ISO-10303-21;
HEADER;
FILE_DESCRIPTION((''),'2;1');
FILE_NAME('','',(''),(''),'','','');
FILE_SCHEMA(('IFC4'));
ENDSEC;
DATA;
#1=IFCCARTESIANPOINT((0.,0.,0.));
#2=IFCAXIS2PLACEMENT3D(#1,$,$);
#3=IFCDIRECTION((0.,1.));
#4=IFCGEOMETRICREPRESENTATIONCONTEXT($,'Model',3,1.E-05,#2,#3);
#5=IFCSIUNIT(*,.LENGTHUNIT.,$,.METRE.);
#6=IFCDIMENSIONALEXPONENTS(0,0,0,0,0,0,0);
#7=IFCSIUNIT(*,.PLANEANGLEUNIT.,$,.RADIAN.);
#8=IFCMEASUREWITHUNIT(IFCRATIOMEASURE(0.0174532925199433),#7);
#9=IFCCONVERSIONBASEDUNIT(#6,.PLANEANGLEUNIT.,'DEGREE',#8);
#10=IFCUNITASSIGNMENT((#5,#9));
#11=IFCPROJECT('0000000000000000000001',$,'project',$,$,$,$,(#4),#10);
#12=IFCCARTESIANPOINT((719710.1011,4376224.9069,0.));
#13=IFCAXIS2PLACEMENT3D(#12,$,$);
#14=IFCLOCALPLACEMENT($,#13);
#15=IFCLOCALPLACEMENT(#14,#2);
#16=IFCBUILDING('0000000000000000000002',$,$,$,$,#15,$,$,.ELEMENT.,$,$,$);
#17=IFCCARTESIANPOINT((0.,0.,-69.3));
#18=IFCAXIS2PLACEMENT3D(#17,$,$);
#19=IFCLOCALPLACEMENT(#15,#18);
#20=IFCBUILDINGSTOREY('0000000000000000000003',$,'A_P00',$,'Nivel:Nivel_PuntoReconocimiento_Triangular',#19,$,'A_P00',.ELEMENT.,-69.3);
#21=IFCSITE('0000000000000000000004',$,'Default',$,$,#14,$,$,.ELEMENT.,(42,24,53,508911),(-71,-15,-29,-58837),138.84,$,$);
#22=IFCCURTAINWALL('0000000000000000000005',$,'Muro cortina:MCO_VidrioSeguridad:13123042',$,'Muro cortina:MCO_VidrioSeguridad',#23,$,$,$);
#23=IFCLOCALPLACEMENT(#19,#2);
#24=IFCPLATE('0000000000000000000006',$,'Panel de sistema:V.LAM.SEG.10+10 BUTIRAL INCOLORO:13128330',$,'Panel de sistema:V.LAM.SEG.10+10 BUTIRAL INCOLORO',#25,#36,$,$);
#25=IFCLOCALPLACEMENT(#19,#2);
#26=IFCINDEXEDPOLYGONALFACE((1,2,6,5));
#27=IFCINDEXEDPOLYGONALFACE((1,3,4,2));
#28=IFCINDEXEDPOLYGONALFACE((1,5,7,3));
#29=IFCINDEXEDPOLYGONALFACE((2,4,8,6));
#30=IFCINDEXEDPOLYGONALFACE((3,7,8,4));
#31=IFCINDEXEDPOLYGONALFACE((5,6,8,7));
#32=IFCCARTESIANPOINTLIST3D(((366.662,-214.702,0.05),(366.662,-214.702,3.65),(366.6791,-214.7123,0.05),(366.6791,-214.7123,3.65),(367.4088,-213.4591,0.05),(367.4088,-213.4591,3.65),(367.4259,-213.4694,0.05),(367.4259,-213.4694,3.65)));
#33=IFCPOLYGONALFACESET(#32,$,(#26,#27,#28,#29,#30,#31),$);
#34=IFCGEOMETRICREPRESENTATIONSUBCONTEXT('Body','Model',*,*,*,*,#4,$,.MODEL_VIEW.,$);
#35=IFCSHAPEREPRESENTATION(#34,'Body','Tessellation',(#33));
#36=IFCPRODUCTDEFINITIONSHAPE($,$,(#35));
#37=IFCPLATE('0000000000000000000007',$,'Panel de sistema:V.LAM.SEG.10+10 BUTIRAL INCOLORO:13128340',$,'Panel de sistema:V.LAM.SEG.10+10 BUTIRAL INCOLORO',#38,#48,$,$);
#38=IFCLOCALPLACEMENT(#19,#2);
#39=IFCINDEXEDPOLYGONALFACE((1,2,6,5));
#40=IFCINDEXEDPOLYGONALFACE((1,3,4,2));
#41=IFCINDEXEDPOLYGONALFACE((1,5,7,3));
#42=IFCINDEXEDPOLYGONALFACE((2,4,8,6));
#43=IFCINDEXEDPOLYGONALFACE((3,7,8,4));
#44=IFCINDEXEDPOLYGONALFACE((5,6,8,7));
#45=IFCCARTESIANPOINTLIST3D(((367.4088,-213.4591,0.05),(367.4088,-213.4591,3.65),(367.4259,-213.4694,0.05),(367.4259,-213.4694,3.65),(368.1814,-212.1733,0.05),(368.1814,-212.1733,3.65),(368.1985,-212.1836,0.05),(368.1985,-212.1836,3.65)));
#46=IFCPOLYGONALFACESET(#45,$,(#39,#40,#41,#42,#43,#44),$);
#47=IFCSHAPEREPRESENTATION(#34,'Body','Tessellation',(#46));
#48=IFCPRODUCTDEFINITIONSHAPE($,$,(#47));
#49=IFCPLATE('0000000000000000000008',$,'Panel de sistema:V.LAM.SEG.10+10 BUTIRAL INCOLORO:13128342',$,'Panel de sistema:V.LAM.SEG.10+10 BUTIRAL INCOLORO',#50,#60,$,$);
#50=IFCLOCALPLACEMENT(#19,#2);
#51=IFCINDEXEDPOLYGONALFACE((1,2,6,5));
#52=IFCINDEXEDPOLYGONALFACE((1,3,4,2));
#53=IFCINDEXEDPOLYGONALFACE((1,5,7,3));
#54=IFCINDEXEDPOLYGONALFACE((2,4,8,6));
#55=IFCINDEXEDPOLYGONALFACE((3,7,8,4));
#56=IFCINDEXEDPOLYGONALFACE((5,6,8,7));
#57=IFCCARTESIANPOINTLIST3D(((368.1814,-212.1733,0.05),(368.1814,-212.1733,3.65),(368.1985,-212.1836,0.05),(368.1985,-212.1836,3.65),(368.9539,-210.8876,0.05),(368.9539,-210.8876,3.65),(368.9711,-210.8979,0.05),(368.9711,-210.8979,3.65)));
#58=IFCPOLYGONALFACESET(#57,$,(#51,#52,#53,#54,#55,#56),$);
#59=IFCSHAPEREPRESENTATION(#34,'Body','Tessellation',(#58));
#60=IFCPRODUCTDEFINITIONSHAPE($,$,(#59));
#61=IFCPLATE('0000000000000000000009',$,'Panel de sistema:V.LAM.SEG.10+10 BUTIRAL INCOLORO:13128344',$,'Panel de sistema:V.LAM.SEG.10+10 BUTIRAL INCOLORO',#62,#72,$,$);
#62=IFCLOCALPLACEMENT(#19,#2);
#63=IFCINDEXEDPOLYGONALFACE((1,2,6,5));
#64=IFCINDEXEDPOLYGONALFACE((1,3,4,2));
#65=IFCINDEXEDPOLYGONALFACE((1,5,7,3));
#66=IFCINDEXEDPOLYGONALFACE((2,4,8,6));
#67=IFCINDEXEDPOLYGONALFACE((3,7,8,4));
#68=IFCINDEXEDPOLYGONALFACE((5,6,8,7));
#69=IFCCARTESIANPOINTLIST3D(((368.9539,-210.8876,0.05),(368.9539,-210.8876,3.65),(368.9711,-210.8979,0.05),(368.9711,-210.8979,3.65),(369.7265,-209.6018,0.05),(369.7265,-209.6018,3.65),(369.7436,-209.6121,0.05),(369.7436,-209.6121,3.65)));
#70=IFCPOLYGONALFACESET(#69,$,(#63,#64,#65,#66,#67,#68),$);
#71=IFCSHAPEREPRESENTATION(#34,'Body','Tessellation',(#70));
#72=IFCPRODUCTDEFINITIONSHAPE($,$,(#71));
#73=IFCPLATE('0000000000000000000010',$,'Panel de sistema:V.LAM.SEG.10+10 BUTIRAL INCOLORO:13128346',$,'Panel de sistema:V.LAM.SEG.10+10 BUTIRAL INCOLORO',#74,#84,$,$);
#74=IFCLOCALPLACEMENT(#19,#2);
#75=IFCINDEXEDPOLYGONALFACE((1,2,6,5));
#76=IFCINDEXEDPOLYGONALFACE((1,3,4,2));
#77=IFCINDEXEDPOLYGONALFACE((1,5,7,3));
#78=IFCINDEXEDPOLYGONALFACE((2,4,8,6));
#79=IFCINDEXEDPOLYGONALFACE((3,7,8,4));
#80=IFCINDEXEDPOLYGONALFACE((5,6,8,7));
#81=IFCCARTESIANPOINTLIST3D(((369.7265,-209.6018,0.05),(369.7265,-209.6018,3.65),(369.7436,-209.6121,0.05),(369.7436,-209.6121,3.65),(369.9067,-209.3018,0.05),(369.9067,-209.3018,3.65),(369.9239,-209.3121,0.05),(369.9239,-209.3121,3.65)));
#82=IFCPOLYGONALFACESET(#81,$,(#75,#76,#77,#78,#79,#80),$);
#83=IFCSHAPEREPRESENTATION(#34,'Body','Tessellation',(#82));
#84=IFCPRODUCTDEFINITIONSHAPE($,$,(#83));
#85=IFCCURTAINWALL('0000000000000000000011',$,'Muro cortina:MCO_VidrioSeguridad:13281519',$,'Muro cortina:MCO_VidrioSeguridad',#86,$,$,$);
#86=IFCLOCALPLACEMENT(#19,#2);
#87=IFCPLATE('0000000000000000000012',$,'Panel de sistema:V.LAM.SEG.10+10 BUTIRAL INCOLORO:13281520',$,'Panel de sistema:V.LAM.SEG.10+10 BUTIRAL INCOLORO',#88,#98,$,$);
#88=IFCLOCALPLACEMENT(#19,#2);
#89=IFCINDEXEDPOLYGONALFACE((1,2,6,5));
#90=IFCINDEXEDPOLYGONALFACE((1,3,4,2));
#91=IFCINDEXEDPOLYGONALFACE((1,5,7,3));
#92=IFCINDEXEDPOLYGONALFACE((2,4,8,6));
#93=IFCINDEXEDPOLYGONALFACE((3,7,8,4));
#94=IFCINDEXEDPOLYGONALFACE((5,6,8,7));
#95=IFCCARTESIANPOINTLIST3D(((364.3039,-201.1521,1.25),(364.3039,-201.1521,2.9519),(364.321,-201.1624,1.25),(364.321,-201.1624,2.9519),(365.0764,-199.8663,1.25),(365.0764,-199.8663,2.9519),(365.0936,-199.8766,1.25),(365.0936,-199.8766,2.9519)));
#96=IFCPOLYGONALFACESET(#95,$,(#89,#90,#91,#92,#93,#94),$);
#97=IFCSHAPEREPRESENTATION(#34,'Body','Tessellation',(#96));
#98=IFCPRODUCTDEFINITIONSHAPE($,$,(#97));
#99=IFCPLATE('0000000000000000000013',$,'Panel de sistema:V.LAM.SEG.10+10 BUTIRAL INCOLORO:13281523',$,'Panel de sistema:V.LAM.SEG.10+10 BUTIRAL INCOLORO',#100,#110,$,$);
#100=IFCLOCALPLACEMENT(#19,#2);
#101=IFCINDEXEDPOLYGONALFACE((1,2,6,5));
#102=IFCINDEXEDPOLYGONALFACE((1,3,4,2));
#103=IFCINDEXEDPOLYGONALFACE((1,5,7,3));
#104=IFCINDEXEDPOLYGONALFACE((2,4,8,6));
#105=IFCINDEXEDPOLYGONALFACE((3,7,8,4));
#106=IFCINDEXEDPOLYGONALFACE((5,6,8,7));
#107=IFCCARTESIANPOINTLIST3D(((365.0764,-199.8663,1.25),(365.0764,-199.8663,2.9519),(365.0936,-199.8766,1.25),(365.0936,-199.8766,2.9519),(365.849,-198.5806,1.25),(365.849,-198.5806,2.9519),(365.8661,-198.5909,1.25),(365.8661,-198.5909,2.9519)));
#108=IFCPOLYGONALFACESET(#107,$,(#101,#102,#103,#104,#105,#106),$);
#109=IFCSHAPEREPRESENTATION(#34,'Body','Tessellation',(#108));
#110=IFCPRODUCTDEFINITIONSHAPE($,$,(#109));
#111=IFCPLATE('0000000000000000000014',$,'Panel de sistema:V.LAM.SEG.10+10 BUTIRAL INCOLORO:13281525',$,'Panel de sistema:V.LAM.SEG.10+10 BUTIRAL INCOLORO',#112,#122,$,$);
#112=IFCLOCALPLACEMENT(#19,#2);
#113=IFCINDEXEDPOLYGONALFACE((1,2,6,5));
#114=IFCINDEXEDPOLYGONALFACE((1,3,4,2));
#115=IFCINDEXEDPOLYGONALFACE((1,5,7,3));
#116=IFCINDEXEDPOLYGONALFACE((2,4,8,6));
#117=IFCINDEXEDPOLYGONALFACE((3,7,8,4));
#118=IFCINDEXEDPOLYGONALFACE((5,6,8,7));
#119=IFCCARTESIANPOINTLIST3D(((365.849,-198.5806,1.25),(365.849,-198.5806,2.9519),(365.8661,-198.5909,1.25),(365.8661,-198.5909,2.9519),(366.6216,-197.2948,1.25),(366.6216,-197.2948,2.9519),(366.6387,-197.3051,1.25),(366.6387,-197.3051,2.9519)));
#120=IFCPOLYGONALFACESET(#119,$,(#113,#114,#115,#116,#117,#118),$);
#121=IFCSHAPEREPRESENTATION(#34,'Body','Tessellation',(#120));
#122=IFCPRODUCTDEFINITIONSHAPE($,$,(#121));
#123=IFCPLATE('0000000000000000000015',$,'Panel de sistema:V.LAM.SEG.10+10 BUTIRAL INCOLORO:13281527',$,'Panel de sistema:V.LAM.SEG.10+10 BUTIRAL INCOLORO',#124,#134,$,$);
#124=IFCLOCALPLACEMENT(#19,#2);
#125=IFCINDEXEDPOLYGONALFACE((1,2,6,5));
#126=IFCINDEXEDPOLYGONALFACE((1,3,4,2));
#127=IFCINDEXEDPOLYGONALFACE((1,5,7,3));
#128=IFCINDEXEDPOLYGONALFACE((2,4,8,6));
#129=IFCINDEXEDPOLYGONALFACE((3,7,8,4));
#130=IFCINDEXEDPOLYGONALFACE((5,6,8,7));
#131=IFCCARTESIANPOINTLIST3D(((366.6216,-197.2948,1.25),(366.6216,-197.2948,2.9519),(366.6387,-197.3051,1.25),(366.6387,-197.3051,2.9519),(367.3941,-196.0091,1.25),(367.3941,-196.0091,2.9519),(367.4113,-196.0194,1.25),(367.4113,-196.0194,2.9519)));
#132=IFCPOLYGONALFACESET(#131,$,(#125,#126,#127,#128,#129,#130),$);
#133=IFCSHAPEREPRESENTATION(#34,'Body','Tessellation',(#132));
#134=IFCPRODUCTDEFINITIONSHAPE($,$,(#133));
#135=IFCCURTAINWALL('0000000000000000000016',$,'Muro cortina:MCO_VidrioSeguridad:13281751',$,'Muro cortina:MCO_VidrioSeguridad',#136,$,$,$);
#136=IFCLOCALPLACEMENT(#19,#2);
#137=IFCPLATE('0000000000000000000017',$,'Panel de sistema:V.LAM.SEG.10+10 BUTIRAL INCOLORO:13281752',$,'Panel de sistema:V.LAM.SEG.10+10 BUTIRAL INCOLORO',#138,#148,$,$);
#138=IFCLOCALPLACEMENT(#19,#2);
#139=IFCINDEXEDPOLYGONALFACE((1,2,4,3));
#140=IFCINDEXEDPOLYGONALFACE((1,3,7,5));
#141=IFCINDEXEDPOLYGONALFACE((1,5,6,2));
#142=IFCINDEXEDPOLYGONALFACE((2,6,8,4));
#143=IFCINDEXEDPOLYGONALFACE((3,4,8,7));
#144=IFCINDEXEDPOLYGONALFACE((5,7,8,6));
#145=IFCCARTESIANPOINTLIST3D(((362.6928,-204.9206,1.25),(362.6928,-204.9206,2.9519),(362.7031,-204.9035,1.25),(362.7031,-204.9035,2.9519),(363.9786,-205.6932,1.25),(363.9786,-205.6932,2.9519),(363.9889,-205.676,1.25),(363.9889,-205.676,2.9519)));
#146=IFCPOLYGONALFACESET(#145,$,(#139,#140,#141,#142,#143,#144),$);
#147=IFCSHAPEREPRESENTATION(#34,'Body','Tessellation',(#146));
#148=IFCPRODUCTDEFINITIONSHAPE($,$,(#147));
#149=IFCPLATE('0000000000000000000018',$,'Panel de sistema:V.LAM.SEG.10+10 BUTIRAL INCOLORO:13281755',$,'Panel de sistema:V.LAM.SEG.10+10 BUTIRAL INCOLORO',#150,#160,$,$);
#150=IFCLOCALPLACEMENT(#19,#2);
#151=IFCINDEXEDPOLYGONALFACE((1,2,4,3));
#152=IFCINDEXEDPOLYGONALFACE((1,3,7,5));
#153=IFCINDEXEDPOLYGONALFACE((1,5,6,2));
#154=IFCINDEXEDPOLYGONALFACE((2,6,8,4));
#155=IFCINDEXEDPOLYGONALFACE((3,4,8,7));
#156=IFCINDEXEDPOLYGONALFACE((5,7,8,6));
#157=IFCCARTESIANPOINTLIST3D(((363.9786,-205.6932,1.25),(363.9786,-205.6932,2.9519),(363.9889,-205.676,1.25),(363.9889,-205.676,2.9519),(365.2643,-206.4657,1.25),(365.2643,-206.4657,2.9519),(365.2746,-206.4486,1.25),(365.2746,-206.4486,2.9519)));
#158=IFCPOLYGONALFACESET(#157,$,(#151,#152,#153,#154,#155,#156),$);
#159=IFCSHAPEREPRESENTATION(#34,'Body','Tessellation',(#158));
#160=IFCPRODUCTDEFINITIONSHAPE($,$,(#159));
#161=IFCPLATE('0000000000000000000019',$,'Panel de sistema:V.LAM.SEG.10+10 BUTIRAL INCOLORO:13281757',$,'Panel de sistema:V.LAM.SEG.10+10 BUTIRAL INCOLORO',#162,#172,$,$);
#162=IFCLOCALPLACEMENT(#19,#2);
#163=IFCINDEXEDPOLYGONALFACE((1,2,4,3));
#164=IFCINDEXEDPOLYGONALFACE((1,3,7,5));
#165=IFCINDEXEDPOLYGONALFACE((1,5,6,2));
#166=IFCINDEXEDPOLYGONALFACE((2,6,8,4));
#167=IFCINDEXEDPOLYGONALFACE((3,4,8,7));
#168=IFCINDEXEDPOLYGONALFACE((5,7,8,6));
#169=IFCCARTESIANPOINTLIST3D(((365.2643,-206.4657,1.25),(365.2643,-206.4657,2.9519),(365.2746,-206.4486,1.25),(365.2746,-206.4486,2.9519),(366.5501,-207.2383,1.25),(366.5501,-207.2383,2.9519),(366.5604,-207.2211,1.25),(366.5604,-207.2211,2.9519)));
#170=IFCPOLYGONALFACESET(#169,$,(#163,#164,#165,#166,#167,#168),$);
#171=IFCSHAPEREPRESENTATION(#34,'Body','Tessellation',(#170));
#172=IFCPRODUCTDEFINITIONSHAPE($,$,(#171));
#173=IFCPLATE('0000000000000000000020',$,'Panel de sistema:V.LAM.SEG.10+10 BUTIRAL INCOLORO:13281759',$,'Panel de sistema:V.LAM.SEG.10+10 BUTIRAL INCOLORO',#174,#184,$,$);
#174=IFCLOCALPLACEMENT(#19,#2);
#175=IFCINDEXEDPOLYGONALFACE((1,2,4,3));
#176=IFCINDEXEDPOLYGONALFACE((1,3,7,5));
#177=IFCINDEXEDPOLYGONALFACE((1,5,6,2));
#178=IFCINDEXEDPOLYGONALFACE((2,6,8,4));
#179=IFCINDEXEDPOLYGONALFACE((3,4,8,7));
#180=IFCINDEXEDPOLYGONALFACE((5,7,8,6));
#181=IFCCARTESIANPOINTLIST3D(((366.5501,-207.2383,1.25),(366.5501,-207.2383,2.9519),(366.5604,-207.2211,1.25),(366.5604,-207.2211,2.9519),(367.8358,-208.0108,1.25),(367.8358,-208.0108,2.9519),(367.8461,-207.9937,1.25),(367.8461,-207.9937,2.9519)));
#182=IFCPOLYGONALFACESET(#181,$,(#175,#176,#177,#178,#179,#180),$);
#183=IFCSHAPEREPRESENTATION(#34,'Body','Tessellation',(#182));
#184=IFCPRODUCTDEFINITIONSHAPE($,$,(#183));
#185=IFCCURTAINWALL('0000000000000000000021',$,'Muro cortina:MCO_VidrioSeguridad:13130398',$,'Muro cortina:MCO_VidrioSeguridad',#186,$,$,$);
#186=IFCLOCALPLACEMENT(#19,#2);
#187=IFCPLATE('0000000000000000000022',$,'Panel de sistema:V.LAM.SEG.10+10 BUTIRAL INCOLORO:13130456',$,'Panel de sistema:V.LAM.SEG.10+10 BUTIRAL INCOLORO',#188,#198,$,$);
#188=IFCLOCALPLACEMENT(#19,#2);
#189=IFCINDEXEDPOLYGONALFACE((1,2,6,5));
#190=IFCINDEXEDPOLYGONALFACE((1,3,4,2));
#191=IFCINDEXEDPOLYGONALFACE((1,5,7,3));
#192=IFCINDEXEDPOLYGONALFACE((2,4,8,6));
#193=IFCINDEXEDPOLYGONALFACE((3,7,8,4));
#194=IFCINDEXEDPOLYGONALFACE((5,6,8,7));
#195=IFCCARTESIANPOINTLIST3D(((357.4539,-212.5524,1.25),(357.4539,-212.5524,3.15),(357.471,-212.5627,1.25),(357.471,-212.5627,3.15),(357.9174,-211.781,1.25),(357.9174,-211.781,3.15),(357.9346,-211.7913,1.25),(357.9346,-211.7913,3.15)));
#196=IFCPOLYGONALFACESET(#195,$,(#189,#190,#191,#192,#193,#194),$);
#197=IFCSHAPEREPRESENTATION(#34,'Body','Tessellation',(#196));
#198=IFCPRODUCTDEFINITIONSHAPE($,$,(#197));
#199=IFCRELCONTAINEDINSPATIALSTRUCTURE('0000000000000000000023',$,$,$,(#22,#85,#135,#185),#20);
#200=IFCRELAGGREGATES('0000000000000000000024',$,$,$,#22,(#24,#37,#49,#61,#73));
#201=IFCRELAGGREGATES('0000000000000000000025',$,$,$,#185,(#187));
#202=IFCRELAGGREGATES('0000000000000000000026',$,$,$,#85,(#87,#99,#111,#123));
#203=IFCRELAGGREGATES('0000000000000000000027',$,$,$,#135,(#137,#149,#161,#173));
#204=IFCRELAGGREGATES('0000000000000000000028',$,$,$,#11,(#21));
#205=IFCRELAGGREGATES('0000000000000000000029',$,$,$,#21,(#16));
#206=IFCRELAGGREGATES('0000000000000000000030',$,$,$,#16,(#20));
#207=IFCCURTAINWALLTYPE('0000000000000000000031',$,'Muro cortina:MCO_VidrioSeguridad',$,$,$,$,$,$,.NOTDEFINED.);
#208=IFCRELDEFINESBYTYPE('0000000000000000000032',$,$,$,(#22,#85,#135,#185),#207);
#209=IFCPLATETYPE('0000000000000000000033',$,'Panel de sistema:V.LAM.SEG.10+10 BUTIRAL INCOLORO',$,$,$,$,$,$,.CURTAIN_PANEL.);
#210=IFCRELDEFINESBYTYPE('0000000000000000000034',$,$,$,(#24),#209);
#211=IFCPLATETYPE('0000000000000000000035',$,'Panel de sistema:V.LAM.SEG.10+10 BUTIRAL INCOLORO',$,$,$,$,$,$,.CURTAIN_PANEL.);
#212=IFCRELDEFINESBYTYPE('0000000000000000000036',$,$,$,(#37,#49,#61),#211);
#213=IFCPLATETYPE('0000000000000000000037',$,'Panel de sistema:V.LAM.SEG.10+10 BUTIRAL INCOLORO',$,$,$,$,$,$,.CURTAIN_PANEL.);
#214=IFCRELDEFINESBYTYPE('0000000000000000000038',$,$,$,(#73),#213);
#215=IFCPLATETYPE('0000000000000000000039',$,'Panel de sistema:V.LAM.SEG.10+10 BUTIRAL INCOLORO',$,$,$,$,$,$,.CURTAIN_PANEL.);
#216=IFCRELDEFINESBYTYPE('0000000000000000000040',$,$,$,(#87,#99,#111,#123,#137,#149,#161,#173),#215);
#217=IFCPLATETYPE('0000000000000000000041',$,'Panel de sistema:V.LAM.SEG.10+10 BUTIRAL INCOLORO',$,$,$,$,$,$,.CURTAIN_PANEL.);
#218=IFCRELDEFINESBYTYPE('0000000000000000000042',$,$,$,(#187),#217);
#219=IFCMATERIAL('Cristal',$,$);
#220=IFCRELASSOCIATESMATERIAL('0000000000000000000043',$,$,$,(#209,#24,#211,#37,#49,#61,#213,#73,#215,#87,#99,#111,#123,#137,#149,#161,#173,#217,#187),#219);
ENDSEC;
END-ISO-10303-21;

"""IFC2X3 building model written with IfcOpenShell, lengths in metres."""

from ifc_helpers import new_model, entity, si_unit, converted_unit, direction, frame, frame_2d, origin, origin_2d_with_axis, place, context, subcontext, project, spatial, rectangle, extrude, source, transform, mapped, material, type_object, type_shapes, element, aggregate, save


model = new_model("IFC2X3")

# Units and contexts
model_context = context("Model", 3, precision=1e-05, world=origin(), true_north=direction((0.0, 1.0)))
body_context = subcontext(model_context, "Body", "Model", "MODEL_VIEW")
ifc_project = project(units=[si_unit("LENGTHUNIT", "METRE"), converted_unit("PLANEANGLEUNIT", "DEGREE", entity("IfcRatioMeasure", 0.0174532925199433), si_unit("PLANEANGLEUNIT", "RADIAN"), dimensions=[0, 0, 0, 0, 0, 0, 0])], contexts=[model_context])

# Site, building, storey
site_placement = place(None, frame((719710.1011, 4376224.9069, 0.0)))
site = spatial("IfcSite", under=ifc_project, at=site_placement, Name="Default", CompositionType="ELEMENT", RefLatitude=(42, 24, 53, 508911), RefLongitude=(-71, -15, -29, -58837), RefElevation=138.84)
building_placement = place(site_placement, origin())
building = spatial("IfcBuilding", under=site, at=building_placement, CompositionType="ELEMENT")
storey_placement = place(building_placement, frame((0.0, 0.0, -69.3)))
storey = spatial("IfcBuildingStorey", under=building, at=storey_placement, Name="A_P00", ObjectType="Nivel:Nivel_PuntoReconocimiento_Triangular", LongName="A_P00", CompositionType="ELEMENT", Elevation=-69.3)

# Curtain walls, plates
curtain_wall_type = type_object("IfcCurtainWallType", Name="Muro cortina:MCO_VidrioSeguridad", PredefinedType="NOTDEFINED")
curtain_wall_1_placement = place(storey_placement, frame((0.0, 0.0, 69.3)))
curtain_wall_1 = element("IfcCurtainWall", 1, at=curtain_wall_1_placement, inside=storey, type_object=curtain_wall_type, Name="Muro cortina:MCO_VidrioSeguridad:13123042", ObjectType="Muro cortina:MCO_VidrioSeguridad")
ifc_material_1 = material(Name="Cristal")
plate_type_1 = type_object("IfcPlateType", Name="Panel de sistema:V.LAM.SEG.10+10 BUTIRAL INCOLORO", PredefinedType="CURTAIN_PANEL", material=ifc_material_1)
shared_shape_1 = source(origin(), body_context, "Body", "SweptSolid", [
    extrude(rectangle(XDim=0.02, YDim=1.45, at=frame_2d((0.0, 0.0), x_axis=(1.0, 0.0))), frame((0.0, 0.0, 0.0), z_axis=(0.0, 0.0, 1.0), x_axis=(0.0, 1.0, 0.0)), (0.0, 0.0, 1.0), 3.6),
])
type_shapes(plate_type_1, [shared_shape_1])
plate_1_placement = place(curtain_wall_1_placement, frame((367.044, -214.0857, -69.25), z_axis=(0.0, 0.0, 1.0), x_axis=(0.515038, 0.857167, 0.0)))
plate_1 = element("IfcPlate", 2, at=plate_1_placement, type_object=plate_type_1, material=ifc_material_1, Name="Panel de sistema:V.LAM.SEG.10+10 BUTIRAL INCOLORO:13128330", ObjectType="Panel de sistema:V.LAM.SEG.10+10 BUTIRAL INCOLORO", context=body_context, shape_type="MappedRepresentation", body=[
    mapped(shared_shape_1, transform((0.0, 0.0, 0.0), scale=1.0)),
])
plate_type_2 = type_object("IfcPlateType", Name="Panel de sistema:V.LAM.SEG.10+10 BUTIRAL INCOLORO", PredefinedType="CURTAIN_PANEL", material=ifc_material_1)
shared_shape_2 = source(origin(), body_context, "Body", "SweptSolid", [
    extrude(rectangle(XDim=0.02, YDim=1.5, at=frame_2d((0.0, 0.0), x_axis=(1.0, 0.0))), frame((0.0, 0.0, 0.0), z_axis=(0.0, 0.0, 1.0), x_axis=(0.0, 1.0, 0.0)), (0.0, 0.0, 1.0), 3.6),
])
type_shapes(plate_type_2, [shared_shape_2])
plate_2_placement = place(curtain_wall_1_placement, frame((367.8036, -212.8213, -69.25), z_axis=(0.0, 0.0, 1.0), x_axis=(0.515038, 0.857167, 0.0)))
plate_2 = element("IfcPlate", 3, at=plate_2_placement, type_object=plate_type_2, material=ifc_material_1, Name="Panel de sistema:V.LAM.SEG.10+10 BUTIRAL INCOLORO:13128340", ObjectType="Panel de sistema:V.LAM.SEG.10+10 BUTIRAL INCOLORO", context=body_context, shape_type="MappedRepresentation", body=[
    mapped(shared_shape_2, transform((0.0, 0.0, 0.0), scale=1.0)),
])
plate_3_placement = place(curtain_wall_1_placement, frame((368.5762, -211.5356, -69.25), z_axis=(0.0, 0.0, 1.0), x_axis=(0.515038, 0.857167, 0.0)))
plate_3 = element("IfcPlate", 4, at=plate_3_placement, type_object=plate_type_2, material=ifc_material_1, Name="Panel de sistema:V.LAM.SEG.10+10 BUTIRAL INCOLORO:13128342", ObjectType="Panel de sistema:V.LAM.SEG.10+10 BUTIRAL INCOLORO", context=body_context, shape_type="MappedRepresentation", body=[
    mapped(shared_shape_2, transform((0.0, 0.0, 0.0), scale=1.0)),
])
plate_4_placement = place(curtain_wall_1_placement, frame((369.3488, -210.2498, -69.25), z_axis=(0.0, 0.0, 1.0), x_axis=(0.515038, 0.857167, 0.0)))
plate_4 = element("IfcPlate", 5, at=plate_4_placement, type_object=plate_type_2, material=ifc_material_1, Name="Panel de sistema:V.LAM.SEG.10+10 BUTIRAL INCOLORO:13128344", ObjectType="Panel de sistema:V.LAM.SEG.10+10 BUTIRAL INCOLORO", context=body_context, shape_type="MappedRepresentation", body=[
    mapped(shared_shape_2, transform((0.0, 0.0, 0.0), scale=1.0)),
])
plate_type_3 = type_object("IfcPlateType", Name="Panel de sistema:V.LAM.SEG.10+10 BUTIRAL INCOLORO", PredefinedType="CURTAIN_PANEL", material=ifc_material_1)
shared_shape_3 = source(origin(), body_context, "Body", "SweptSolid", [
    extrude(rectangle(XDim=0.02, YDim=0.35, at=origin_2d_with_axis()), frame((0.0, 0.0, 0.0), z_axis=(0.0, 0.0, 1.0), x_axis=(0.0, 1.0, 0.0)), (0.0, 0.0, 1.0), 3.6),
])
type_shapes(plate_type_3, [shared_shape_3])
plate_5_placement = place(curtain_wall_1_placement, frame((369.8252, -209.457, -69.25), z_axis=(0.0, 0.0, 1.0), x_axis=(0.515038, 0.857167, 0.0)))
plate_5 = element("IfcPlate", 6, at=plate_5_placement, type_object=plate_type_3, material=ifc_material_1, Name="Panel de sistema:V.LAM.SEG.10+10 BUTIRAL INCOLORO:13128346", ObjectType="Panel de sistema:V.LAM.SEG.10+10 BUTIRAL INCOLORO", context=body_context, shape_type="MappedRepresentation", body=[
    mapped(shared_shape_3, transform((0.0, 0.0, 0.0), scale=1.0)),
])
aggregate(curtain_wall_1, [plate_1, plate_2, plate_3, plate_4, plate_5])
curtain_wall_2_placement = place(storey_placement, frame((0.0, 0.0, 69.3)))
curtain_wall_2 = element("IfcCurtainWall", 7, at=curtain_wall_2_placement, inside=storey, type_object=curtain_wall_type, Name="Muro cortina:MCO_VidrioSeguridad:13281519", ObjectType="Muro cortina:MCO_VidrioSeguridad")
plate_type_4 = type_object("IfcPlateType", Name="Panel de sistema:V.LAM.SEG.10+10 BUTIRAL INCOLORO", PredefinedType="CURTAIN_PANEL", material=ifc_material_1)
shared_shape_4 = source(origin(), body_context, "Body", "SweptSolid", [
    extrude(rectangle(XDim=0.02, YDim=1.5, at=frame_2d((0.0, 0.0), x_axis=(1.0, 0.0))), frame((0.0, 0.0, 0.0), z_axis=(0.0, 0.0, 1.0), x_axis=(0.0, 1.0, 0.0)), (0.0, 0.0, 1.0), 1.7019),
])
type_shapes(plate_type_4, [shared_shape_4])
plate_6_placement = place(curtain_wall_2_placement, frame((364.6987, -200.5144, -68.05), z_axis=(0.0, 0.0, 1.0), x_axis=(0.515038, 0.857167, 0.0)))
plate_6 = element("IfcPlate", 8, at=plate_6_placement, type_object=plate_type_4, material=ifc_material_1, Name="Panel de sistema:V.LAM.SEG.10+10 BUTIRAL INCOLORO:13281520", ObjectType="Panel de sistema:V.LAM.SEG.10+10 BUTIRAL INCOLORO", context=body_context, shape_type="MappedRepresentation", body=[
    mapped(shared_shape_4, transform((0.0, 0.0, 0.0), scale=1.0)),
])
plate_7_placement = place(curtain_wall_2_placement, frame((365.4713, -199.2286, -68.05), z_axis=(0.0, 0.0, 1.0), x_axis=(0.515038, 0.857167, 0.0)))
plate_7 = element("IfcPlate", 9, at=plate_7_placement, type_object=plate_type_4, material=ifc_material_1, Name="Panel de sistema:V.LAM.SEG.10+10 BUTIRAL INCOLORO:13281523", ObjectType="Panel de sistema:V.LAM.SEG.10+10 BUTIRAL INCOLORO", context=body_context, shape_type="MappedRepresentation", body=[
    mapped(shared_shape_4, transform((0.0, 0.0, 0.0), scale=1.0)),
])
plate_8_placement = place(curtain_wall_2_placement, frame((366.2438, -197.9429, -68.05), z_axis=(0.0, 0.0, 1.0), x_axis=(0.515038, 0.857167, 0.0)))
plate_8 = element("IfcPlate", 10, at=plate_8_placement, type_object=plate_type_4, material=ifc_material_1, Name="Panel de sistema:V.LAM.SEG.10+10 BUTIRAL INCOLORO:13281525", ObjectType="Panel de sistema:V.LAM.SEG.10+10 BUTIRAL INCOLORO", context=body_context, shape_type="MappedRepresentation", body=[
    mapped(shared_shape_4, transform((0.0, 0.0, 0.0), scale=1.0)),
])
plate_9_placement = place(curtain_wall_2_placement, frame((367.0164, -196.6571, -68.05), z_axis=(0.0, 0.0, 1.0), x_axis=(0.515038, 0.857167, 0.0)))
plate_9 = element("IfcPlate", 11, at=plate_9_placement, type_object=plate_type_4, material=ifc_material_1, Name="Panel de sistema:V.LAM.SEG.10+10 BUTIRAL INCOLORO:13281527", ObjectType="Panel de sistema:V.LAM.SEG.10+10 BUTIRAL INCOLORO", context=body_context, shape_type="MappedRepresentation", body=[
    mapped(shared_shape_4, transform((0.0, 0.0, 0.0), scale=1.0)),
])
curtain_wall_3_placement = place(storey_placement, frame((0.0, 0.0, 69.3)))
curtain_wall_3 = element("IfcCurtainWall", 12, at=curtain_wall_3_placement, inside=storey, type_object=curtain_wall_type, Name="Muro cortina:MCO_VidrioSeguridad:13281751", ObjectType="Muro cortina:MCO_VidrioSeguridad")
plate_10_placement = place(curtain_wall_3_placement, frame((363.3409, -205.2983, -68.05), z_axis=(0.0, 0.0, 1.0), x_axis=(0.857167, -0.515038, 0.0)))
plate_10 = element("IfcPlate", 13, at=plate_10_placement, type_object=plate_type_4, material=ifc_material_1, Name="Panel de sistema:V.LAM.SEG.10+10 BUTIRAL INCOLORO:13281752", ObjectType="Panel de sistema:V.LAM.SEG.10+10 BUTIRAL INCOLORO", context=body_context, shape_type="MappedRepresentation", body=[
    mapped(shared_shape_4, transform((0.0, 0.0, 0.0), scale=1.0)),
])
plate_11_placement = place(curtain_wall_3_placement, frame((364.6266, -206.0709, -68.05), z_axis=(0.0, 0.0, 1.0), x_axis=(0.857167, -0.515038, 0.0)))
plate_11 = element("IfcPlate", 14, at=plate_11_placement, type_object=plate_type_4, material=ifc_material_1, Name="Panel de sistema:V.LAM.SEG.10+10 BUTIRAL INCOLORO:13281755", ObjectType="Panel de sistema:V.LAM.SEG.10+10 BUTIRAL INCOLORO", context=body_context, shape_type="MappedRepresentation", body=[
    mapped(shared_shape_4, transform((0.0, 0.0, 0.0), scale=1.0)),
])
plate_12_placement = place(curtain_wall_3_placement, frame((365.9124, -206.8434, -68.05), z_axis=(0.0, 0.0, 1.0), x_axis=(0.857167, -0.515038, 0.0)))
plate_12 = element("IfcPlate", 15, at=plate_12_placement, type_object=plate_type_4, material=ifc_material_1, Name="Panel de sistema:V.LAM.SEG.10+10 BUTIRAL INCOLORO:13281757", ObjectType="Panel de sistema:V.LAM.SEG.10+10 BUTIRAL INCOLORO", context=body_context, shape_type="MappedRepresentation", body=[
    mapped(shared_shape_4, transform((0.0, 0.0, 0.0), scale=1.0)),
])
plate_13_placement = place(curtain_wall_3_placement, frame((367.1981, -207.616, -68.05), z_axis=(0.0, 0.0, 1.0), x_axis=(0.857167, -0.515038, 0.0)))
plate_13 = element("IfcPlate", 16, at=plate_13_placement, type_object=plate_type_4, material=ifc_material_1, Name="Panel de sistema:V.LAM.SEG.10+10 BUTIRAL INCOLORO:13281759", ObjectType="Panel de sistema:V.LAM.SEG.10+10 BUTIRAL INCOLORO", context=body_context, shape_type="MappedRepresentation", body=[
    mapped(shared_shape_4, transform((0.0, 0.0, 0.0), scale=1.0)),
])

# Curtain wall, plate
curtain_wall_4_placement = place(storey_placement, frame((0.0, 0.0, 69.3)))
curtain_wall_4 = element("IfcCurtainWall", 17, at=curtain_wall_4_placement, inside=storey, type_object=curtain_wall_type, Name="Muro cortina:MCO_VidrioSeguridad:13130398", ObjectType="Muro cortina:MCO_VidrioSeguridad")
plate_type_5 = type_object("IfcPlateType", Name="Panel de sistema:V.LAM.SEG.10+10 BUTIRAL INCOLORO", PredefinedType="CURTAIN_PANEL", material=ifc_material_1)
shared_shape_5 = source(origin(), body_context, "Body", "SweptSolid", [
    extrude(rectangle(XDim=0.02, YDim=0.9, at=origin_2d_with_axis()), frame((0.0, 0.0, 0.0), z_axis=(0.0, 0.0, 1.0), x_axis=(0.0, 1.0, 0.0)), (0.0, 0.0, 1.0), 1.9),
])
type_shapes(plate_type_5, [shared_shape_5])
plate_14_placement = place(curtain_wall_4_placement, frame((357.6942, -212.1718, -68.05), z_axis=(0.0, 0.0, 1.0), x_axis=(0.515038, 0.857167, 0.0)))
plate_14 = element("IfcPlate", 18, at=plate_14_placement, type_object=plate_type_5, material=ifc_material_1, Name="Panel de sistema:V.LAM.SEG.10+10 BUTIRAL INCOLORO:13130456", ObjectType="Panel de sistema:V.LAM.SEG.10+10 BUTIRAL INCOLORO", context=body_context, shape_type="MappedRepresentation", body=[
    mapped(shared_shape_5, transform((0.0, 0.0, 0.0), scale=1.0)),
])
aggregate(curtain_wall_4, [plate_14])

aggregate(curtain_wall_2, [plate_6, plate_7, plate_8, plate_9])
aggregate(curtain_wall_3, [plate_10, plate_11, plate_12, plate_13])

save(model, "model.ifc")
